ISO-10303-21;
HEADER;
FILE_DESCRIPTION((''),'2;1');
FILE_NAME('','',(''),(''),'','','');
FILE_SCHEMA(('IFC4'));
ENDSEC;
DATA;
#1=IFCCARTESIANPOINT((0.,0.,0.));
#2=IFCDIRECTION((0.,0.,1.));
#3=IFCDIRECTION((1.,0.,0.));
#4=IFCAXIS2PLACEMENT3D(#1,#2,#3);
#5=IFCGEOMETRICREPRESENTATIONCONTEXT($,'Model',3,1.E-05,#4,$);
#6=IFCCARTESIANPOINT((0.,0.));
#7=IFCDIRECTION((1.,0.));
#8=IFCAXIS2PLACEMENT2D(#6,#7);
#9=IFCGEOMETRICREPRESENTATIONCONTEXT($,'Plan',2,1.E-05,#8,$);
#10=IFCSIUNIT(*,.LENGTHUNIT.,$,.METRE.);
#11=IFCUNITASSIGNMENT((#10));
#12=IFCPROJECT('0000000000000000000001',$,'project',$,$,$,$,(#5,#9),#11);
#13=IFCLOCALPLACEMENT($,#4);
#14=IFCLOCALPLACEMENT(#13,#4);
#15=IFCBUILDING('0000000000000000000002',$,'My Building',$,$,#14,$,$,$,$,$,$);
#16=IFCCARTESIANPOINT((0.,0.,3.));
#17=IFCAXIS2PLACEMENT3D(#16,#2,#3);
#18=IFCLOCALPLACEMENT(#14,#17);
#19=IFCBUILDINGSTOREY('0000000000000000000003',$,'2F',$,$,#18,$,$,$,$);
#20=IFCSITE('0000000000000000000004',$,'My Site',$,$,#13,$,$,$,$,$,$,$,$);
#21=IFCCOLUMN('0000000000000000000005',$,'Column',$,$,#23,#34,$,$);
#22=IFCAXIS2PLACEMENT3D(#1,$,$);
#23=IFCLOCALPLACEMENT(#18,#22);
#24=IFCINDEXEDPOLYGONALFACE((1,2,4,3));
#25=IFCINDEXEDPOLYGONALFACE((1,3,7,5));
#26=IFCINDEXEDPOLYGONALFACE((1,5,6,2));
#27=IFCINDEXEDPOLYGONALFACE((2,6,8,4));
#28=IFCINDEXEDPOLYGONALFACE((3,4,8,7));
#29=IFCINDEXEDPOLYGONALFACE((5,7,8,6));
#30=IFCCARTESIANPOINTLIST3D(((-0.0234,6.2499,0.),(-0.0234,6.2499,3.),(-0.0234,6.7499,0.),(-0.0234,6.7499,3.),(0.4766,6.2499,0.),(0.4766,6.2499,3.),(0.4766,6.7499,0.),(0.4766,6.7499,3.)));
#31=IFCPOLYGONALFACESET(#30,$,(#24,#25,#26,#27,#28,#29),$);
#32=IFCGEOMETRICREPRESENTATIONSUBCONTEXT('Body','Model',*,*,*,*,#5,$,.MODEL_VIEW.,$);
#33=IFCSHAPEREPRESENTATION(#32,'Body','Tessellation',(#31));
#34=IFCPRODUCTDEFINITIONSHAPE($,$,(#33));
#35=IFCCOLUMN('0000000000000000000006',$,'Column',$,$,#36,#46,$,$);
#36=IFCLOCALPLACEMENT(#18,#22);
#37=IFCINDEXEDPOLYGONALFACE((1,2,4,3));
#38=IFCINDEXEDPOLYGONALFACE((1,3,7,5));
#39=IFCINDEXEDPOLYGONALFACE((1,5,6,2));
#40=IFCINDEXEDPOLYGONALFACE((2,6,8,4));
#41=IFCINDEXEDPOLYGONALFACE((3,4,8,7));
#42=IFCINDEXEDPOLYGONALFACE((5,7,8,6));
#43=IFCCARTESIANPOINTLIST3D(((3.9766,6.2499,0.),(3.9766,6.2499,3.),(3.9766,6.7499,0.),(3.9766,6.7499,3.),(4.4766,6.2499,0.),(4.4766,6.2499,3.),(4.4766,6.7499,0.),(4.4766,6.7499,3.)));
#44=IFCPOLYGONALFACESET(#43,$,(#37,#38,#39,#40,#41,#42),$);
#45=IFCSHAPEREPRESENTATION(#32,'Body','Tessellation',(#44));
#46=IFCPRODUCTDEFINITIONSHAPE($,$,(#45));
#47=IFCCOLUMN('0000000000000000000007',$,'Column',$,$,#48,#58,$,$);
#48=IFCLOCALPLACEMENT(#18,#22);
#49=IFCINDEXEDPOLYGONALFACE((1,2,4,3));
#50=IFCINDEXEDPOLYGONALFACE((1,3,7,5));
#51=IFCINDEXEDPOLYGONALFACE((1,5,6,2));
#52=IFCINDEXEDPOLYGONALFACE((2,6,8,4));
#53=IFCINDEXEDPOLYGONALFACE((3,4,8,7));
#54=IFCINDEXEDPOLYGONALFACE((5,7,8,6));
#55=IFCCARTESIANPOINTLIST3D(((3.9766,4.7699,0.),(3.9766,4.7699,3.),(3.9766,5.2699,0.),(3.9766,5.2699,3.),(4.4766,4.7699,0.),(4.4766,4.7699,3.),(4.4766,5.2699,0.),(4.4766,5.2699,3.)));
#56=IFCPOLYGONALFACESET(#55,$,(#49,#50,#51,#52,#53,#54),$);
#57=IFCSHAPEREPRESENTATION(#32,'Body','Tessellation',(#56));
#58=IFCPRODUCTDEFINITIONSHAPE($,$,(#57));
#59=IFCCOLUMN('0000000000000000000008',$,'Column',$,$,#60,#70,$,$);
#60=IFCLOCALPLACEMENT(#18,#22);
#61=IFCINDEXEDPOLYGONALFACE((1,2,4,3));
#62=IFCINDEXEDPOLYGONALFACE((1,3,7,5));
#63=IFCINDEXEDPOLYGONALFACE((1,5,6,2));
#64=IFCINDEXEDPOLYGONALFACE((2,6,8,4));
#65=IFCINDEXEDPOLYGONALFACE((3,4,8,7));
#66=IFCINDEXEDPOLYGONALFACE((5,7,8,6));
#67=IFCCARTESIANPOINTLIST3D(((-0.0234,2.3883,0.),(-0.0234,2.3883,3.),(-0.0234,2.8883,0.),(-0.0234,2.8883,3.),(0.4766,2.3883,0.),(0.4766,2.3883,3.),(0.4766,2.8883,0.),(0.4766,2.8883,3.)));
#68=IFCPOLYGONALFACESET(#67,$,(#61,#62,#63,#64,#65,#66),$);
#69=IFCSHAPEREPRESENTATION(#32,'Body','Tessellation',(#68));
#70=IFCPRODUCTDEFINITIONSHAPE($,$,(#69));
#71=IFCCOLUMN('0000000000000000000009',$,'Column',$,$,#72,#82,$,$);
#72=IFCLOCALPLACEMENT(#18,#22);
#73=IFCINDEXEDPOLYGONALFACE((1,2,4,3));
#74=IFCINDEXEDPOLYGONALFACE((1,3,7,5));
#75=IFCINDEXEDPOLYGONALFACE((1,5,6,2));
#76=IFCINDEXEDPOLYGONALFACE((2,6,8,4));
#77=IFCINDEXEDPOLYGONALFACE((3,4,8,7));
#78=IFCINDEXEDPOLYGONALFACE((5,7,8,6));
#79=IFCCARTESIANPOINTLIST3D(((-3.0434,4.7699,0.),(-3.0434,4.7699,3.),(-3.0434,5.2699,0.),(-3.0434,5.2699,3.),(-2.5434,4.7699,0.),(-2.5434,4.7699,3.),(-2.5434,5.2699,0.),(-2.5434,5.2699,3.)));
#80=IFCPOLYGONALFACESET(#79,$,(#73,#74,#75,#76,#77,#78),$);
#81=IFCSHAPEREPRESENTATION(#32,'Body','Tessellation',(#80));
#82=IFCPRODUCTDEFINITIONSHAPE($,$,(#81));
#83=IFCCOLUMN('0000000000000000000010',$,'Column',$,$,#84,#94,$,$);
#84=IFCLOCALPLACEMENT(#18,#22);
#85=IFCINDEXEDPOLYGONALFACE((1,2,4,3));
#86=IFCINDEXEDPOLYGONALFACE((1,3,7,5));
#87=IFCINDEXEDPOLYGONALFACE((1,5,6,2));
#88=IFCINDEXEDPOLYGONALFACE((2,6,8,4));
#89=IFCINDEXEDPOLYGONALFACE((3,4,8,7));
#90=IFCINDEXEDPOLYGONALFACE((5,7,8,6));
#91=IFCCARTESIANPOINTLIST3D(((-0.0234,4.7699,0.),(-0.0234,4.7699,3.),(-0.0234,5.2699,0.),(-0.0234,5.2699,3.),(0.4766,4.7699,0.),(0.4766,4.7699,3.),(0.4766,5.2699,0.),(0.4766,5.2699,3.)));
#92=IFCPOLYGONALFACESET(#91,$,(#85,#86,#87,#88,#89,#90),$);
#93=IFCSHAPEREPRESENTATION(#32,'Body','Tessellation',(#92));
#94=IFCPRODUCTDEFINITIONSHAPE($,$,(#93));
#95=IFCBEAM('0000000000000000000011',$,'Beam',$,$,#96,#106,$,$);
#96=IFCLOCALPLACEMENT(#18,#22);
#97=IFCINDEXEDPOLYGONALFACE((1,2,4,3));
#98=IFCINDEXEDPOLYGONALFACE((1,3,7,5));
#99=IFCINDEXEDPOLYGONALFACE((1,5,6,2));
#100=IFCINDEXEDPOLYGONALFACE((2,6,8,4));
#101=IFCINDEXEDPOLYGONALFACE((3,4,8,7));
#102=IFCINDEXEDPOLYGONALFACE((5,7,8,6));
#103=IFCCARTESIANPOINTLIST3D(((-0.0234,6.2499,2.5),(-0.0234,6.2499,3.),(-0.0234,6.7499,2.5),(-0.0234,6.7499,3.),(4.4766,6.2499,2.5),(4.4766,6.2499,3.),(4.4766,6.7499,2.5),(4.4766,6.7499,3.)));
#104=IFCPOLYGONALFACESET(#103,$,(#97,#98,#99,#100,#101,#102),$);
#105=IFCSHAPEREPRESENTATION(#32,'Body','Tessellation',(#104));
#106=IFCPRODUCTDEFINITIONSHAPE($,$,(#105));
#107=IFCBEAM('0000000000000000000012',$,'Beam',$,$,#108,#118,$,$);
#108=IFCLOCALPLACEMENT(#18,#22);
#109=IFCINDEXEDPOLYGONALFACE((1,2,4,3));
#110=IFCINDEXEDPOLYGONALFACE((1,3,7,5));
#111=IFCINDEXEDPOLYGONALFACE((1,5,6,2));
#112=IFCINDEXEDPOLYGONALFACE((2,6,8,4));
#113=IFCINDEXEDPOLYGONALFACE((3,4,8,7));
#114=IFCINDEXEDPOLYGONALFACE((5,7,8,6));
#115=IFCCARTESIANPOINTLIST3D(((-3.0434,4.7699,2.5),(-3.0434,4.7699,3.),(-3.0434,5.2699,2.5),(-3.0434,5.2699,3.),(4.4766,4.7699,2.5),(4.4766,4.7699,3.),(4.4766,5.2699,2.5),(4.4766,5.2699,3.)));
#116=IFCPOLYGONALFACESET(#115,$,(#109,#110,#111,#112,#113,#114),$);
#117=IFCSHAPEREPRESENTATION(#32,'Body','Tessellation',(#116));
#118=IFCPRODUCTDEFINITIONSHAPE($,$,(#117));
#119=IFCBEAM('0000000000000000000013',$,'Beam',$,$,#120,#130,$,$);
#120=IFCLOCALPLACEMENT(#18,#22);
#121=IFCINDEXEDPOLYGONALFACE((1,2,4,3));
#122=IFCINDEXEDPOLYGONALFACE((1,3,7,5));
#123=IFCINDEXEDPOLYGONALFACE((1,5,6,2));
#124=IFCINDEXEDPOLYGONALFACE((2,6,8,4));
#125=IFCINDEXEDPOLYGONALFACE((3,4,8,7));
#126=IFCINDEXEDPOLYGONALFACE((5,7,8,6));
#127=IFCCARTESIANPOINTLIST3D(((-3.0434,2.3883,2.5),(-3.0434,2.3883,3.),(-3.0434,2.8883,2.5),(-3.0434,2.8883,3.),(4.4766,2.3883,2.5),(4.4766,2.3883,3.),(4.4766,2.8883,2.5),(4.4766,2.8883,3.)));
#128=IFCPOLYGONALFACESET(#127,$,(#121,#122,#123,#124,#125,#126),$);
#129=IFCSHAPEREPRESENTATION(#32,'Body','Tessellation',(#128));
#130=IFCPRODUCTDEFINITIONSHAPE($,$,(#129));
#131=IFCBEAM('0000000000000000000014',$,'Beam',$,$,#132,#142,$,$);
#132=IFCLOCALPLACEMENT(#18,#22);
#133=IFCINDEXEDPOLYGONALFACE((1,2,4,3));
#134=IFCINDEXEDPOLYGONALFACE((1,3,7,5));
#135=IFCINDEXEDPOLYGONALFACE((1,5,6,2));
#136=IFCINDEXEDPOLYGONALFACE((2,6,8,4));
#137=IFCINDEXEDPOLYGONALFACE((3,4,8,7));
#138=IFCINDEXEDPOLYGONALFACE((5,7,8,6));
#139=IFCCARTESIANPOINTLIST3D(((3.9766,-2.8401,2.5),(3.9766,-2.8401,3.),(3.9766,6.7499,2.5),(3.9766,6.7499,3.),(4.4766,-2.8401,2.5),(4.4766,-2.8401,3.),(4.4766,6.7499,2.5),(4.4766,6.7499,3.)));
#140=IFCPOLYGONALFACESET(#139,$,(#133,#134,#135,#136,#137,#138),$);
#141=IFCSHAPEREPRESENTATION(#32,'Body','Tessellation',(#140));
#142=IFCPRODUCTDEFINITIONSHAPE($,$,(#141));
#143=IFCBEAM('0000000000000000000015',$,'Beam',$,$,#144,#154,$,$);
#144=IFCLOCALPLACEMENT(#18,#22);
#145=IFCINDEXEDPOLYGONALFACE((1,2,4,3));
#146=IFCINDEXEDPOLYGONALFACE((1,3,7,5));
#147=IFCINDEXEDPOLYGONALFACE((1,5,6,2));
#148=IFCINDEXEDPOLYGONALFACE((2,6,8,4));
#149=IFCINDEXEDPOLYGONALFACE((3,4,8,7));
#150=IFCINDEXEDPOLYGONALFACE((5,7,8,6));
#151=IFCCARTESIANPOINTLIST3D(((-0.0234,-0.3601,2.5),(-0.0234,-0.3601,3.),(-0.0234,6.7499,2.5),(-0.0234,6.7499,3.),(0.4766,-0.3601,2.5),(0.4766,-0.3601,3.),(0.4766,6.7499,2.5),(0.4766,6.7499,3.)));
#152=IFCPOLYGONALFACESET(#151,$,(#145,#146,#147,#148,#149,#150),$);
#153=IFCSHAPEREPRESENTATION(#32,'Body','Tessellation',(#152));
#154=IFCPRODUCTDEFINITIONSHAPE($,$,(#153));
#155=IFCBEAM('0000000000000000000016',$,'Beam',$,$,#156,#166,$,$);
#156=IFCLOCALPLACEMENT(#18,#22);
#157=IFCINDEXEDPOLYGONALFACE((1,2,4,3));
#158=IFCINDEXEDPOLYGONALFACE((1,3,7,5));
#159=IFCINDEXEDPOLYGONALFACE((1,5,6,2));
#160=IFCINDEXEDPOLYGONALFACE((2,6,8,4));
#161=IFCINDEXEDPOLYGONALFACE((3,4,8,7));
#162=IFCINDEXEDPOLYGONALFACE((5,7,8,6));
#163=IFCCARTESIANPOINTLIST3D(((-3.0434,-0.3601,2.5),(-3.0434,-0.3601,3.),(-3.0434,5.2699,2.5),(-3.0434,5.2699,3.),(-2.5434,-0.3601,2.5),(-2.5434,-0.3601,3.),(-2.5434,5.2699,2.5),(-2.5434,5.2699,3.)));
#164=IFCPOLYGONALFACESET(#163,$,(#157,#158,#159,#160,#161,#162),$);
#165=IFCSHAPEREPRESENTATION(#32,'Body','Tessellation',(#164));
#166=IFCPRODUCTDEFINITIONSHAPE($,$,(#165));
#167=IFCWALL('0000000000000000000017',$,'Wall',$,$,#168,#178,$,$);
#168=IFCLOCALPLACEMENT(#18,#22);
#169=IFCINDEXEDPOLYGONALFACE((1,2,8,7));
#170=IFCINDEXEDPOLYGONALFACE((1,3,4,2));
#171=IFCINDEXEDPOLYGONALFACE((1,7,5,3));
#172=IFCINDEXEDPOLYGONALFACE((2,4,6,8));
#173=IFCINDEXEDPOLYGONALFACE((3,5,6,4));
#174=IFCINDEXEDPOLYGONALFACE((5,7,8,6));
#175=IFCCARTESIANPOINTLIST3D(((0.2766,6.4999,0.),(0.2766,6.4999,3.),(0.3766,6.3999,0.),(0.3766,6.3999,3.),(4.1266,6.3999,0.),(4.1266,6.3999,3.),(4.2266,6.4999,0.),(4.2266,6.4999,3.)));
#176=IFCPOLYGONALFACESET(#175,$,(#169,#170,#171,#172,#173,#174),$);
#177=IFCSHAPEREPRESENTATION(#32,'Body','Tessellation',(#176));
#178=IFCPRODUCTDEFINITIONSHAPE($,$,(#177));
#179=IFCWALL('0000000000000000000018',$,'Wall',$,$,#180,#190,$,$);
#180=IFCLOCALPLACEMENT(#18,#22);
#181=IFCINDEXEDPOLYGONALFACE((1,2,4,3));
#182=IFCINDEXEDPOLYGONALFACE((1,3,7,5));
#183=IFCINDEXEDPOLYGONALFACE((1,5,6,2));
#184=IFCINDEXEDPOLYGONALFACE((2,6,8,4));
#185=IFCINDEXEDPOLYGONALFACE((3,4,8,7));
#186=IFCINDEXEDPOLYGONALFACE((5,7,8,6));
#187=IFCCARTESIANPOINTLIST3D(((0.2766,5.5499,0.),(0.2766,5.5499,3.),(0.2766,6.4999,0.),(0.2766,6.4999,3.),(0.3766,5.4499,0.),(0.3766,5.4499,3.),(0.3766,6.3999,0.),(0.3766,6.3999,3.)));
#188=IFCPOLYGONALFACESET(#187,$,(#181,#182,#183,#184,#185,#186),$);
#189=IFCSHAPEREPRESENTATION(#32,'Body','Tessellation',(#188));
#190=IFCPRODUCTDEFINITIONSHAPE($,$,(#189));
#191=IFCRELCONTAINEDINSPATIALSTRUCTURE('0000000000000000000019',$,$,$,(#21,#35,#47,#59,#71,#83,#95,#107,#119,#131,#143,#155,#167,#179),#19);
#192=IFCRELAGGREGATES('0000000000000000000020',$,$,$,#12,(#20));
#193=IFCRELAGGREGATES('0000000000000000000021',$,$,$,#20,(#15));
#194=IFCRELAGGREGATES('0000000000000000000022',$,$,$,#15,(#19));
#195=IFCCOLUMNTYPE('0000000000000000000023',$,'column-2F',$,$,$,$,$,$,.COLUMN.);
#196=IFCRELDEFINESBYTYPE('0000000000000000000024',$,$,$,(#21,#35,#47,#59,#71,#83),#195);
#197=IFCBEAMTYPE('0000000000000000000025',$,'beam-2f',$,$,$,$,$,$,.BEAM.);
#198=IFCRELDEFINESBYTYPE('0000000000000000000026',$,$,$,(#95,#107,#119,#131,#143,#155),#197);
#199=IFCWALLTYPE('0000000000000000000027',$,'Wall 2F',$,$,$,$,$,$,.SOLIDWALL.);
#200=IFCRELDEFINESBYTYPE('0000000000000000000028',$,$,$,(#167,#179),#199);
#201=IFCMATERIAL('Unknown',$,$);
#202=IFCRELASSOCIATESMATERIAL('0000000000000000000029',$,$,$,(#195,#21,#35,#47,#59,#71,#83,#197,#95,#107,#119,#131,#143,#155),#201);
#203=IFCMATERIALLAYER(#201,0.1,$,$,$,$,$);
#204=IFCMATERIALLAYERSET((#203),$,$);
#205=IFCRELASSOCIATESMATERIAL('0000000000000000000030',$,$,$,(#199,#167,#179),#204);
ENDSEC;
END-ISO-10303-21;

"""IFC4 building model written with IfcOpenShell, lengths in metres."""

from ifc_helpers import new_model, si_unit, frame, origin_with_axes, origin_2d_with_axis, place, context, subcontext, project, spatial, line, indexed_curve, rectangle, outline, extrude, material, layer, layer_set, layer_usage, material_profile, profile_set, profile_usage, type_object, element, save


model = new_model("IFC4")

# Units and contexts
model_context = context("Model", 3, precision=1e-05, world=origin_with_axes())
plan_context = context("Plan", 2, precision=1e-05, world=origin_2d_with_axis())
body_context_1 = subcontext(model_context, "Body", "Model", "MODEL_VIEW")
ifc_project = project(units=[si_unit("LENGTHUNIT", "METRE")], contexts=[model_context, plan_context])

# Site, building, storey
site_placement = place(None, origin_with_axes())
site = spatial("IfcSite", under=ifc_project, at=site_placement, Name="My Site")
building_placement = place(site_placement, origin_with_axes())
building = spatial("IfcBuilding", under=site, at=building_placement, Name="My Building")
storey_placement = place(building_placement, frame((0.0, 0.0, 3.0), z_axis=(0.0, 0.0, 1.0), x_axis=(1.0, 0.0, 0.0)))
storey = spatial("IfcBuildingStorey", under=building, at=storey_placement, Name="2F")

# Columns
ifc_material = material(Name="Unknown")
ifc_material_profile_1 = material_profile(ifc_material, rectangle(XDim=0.5, YDim=0.5))
ifc_profile_set_1 = profile_set([ifc_material_profile_1])
ifc_profile_usage_1 = profile_usage(ifc_profile_set_1, cardinal=7)
column_type = type_object("IfcColumnType", Name="column-2F", PredefinedType="COLUMN", material=ifc_profile_set_1)
column_1_placement = place(storey_placement, frame((0.4766, 6.7499, 0.0), z_axis=(0.0, 0.0, 1.0), x_axis=(1.0, 0.0, 0.0)))
element("IfcColumn", 1, at=column_1_placement, inside=storey, type_object=column_type, material=ifc_profile_usage_1, Name="Column", context=body_context_1, shape_type="SweptSolid", body=[
    extrude(rectangle(XDim=0.5, YDim=0.5), frame((-0.25, -0.25, 0.0), z_axis=(0.0, 0.0, 1.0), x_axis=(1.0, 0.0, 0.0)), (0.0, 0.0, 1.0), 3.0),
])
ifc_profile_usage_2 = profile_usage(ifc_profile_set_1, cardinal=7)
column_2_placement = place(storey_placement, frame((4.4766, 6.7499, 0.0), z_axis=(0.0, 0.0, 1.0), x_axis=(1.0, 0.0, 0.0)))
element("IfcColumn", 2, at=column_2_placement, inside=storey, type_object=column_type, material=ifc_profile_usage_2, Name="Column", context=body_context_1, shape_type="SweptSolid", body=[
    extrude(rectangle(XDim=0.5, YDim=0.5), frame((-0.25, -0.25, 0.0), z_axis=(0.0, 0.0, 1.0), x_axis=(1.0, 0.0, 0.0)), (0.0, 0.0, 1.0), 3.0),
])
ifc_profile_usage_3 = profile_usage(ifc_profile_set_1, cardinal=7)
column_3_placement = place(storey_placement, frame((4.4766, 5.2699, 0.0), z_axis=(0.0, 0.0, 1.0), x_axis=(1.0, 0.0, 0.0)))
element("IfcColumn", 3, at=column_3_placement, inside=storey, type_object=column_type, material=ifc_profile_usage_3, Name="Column", context=body_context_1, shape_type="SweptSolid", body=[
    extrude(rectangle(XDim=0.5, YDim=0.5), frame((-0.25, -0.25, 0.0), z_axis=(0.0, 0.0, 1.0), x_axis=(1.0, 0.0, 0.0)), (0.0, 0.0, 1.0), 3.0),
])
ifc_profile_usage_4 = profile_usage(ifc_profile_set_1, cardinal=7)
column_4_placement = place(storey_placement, frame((0.4766, 2.8883, 0.0), z_axis=(0.0, 0.0, 1.0), x_axis=(1.0, 0.0, 0.0)))
element("IfcColumn", 4, at=column_4_placement, inside=storey, type_object=column_type, material=ifc_profile_usage_4, Name="Column", context=body_context_1, shape_type="SweptSolid", body=[
    extrude(rectangle(XDim=0.5, YDim=0.5), frame((-0.25, -0.25, 0.0), z_axis=(0.0, 0.0, 1.0), x_axis=(1.0, 0.0, 0.0)), (0.0, 0.0, 1.0), 3.0),
])
ifc_profile_usage_5 = profile_usage(ifc_profile_set_1, cardinal=7)
column_5_placement = place(storey_placement, frame((-2.5434, 5.2699, 0.0), z_axis=(0.0, 0.0, 1.0), x_axis=(1.0, 0.0, 0.0)))
element("IfcColumn", 5, at=column_5_placement, inside=storey, type_object=column_type, material=ifc_profile_usage_5, Name="Column", context=body_context_1, shape_type="SweptSolid", body=[
    extrude(rectangle(XDim=0.5, YDim=0.5), frame((-0.25, -0.25, 0.0), z_axis=(0.0, 0.0, 1.0), x_axis=(1.0, 0.0, 0.0)), (0.0, 0.0, 1.0), 3.0),
])
ifc_profile_usage_6 = profile_usage(ifc_profile_set_1, cardinal=7)
column_6_placement = place(storey_placement, frame((0.4766, 5.2699, 0.0), z_axis=(0.0, 0.0, 1.0), x_axis=(1.0, 0.0, 0.0)))
element("IfcColumn", 6, at=column_6_placement, inside=storey, type_object=column_type, material=ifc_profile_usage_6, Name="Column", context=body_context_1, shape_type="SweptSolid", body=[
    extrude(rectangle(XDim=0.5, YDim=0.5), frame((-0.25, -0.25, 0.0), z_axis=(0.0, 0.0, 1.0), x_axis=(1.0, 0.0, 0.0)), (0.0, 0.0, 1.0), 3.0),
])

# Beams
ifc_material_profile_2 = material_profile(ifc_material, rectangle(XDim=0.5, YDim=0.5))
ifc_profile_set_2 = profile_set([ifc_material_profile_2])
ifc_profile_usage_7 = profile_usage(ifc_profile_set_2, cardinal=7)
beam_type = type_object("IfcBeamType", Name="beam-2f", PredefinedType="BEAM", material=ifc_profile_set_2)
beam_1_placement = place(storey_placement, frame((-0.0234, 6.7499, 3.0), z_axis=(1.0, -0.000001, 0.000001), x_axis=(0.000001, 1.0, 0.0)))
element("IfcBeam", 7, at=beam_1_placement, inside=storey, type_object=beam_type, material=ifc_profile_usage_7, Name="Beam", context=body_context_1, shape_type="SweptSolid", body=[
    extrude(rectangle(XDim=0.5, YDim=0.5), frame((-0.25, -0.25, 0.0), z_axis=(0.0, 0.0, 1.0), x_axis=(1.0, 0.0, 0.0)), (0.0, 0.0, 1.0), 4.5),
])
ifc_profile_usage_8 = profile_usage(ifc_profile_set_2, cardinal=7)
beam_2_placement = place(storey_placement, frame((-3.0434, 5.2699, 3.0), z_axis=(1.0, -0.000001, 0.000001), x_axis=(0.000001, 1.0, 0.0)))
element("IfcBeam", 8, at=beam_2_placement, inside=storey, type_object=beam_type, material=ifc_profile_usage_8, Name="Beam", context=body_context_1, shape_type="SweptSolid", body=[
    extrude(rectangle(XDim=0.5, YDim=0.5), frame((-0.25, -0.25, 0.0), z_axis=(0.0, 0.0, 1.0), x_axis=(1.0, 0.0, 0.0)), (0.0, 0.0, 1.0), 7.52),
])
ifc_profile_usage_9 = profile_usage(ifc_profile_set_2, cardinal=7)
beam_3_placement = place(storey_placement, frame((-3.0434, 2.8883, 3.0), z_axis=(1.0, -0.000001, 0.000001), x_axis=(0.000001, 1.0, 0.0)))
element("IfcBeam", 9, at=beam_3_placement, inside=storey, type_object=beam_type, material=ifc_profile_usage_9, Name="Beam", context=body_context_1, shape_type="SweptSolid", body=[
    extrude(rectangle(XDim=0.5, YDim=0.5), frame((-0.25, -0.25, 0.0), z_axis=(0.0, 0.0, 1.0), x_axis=(1.0, 0.0, 0.0)), (0.0, 0.0, 1.0), 7.52),
])
ifc_profile_usage_10 = profile_usage(ifc_profile_set_2, cardinal=7)
beam_4_placement = place(storey_placement, frame((4.4766, 6.7499, 3.0), z_axis=(0.0, -1.0, 0.0), x_axis=(1.0, 0.0, 0.0)))
element("IfcBeam", 10, at=beam_4_placement, inside=storey, type_object=beam_type, material=ifc_profile_usage_10, Name="Beam", context=body_context_1, shape_type="SweptSolid", body=[
    extrude(rectangle(XDim=0.5, YDim=0.5), frame((-0.25, -0.25, 0.0), z_axis=(0.0, 0.0, 1.0), x_axis=(1.0, 0.0, 0.0)), (0.0, 0.0, 1.0), 9.59),
])
ifc_profile_usage_11 = profile_usage(ifc_profile_set_2, cardinal=7)
beam_5_placement = place(storey_placement, frame((0.4766, 6.7499, 3.0), z_axis=(0.0, -1.0, 0.0), x_axis=(1.0, 0.0, 0.0)))
element("IfcBeam", 11, at=beam_5_placement, inside=storey, type_object=beam_type, material=ifc_profile_usage_11, Name="Beam", context=body_context_1, shape_type="SweptSolid", body=[
    extrude(rectangle(XDim=0.5, YDim=0.5), frame((-0.25, -0.25, 0.0), z_axis=(0.0, 0.0, 1.0), x_axis=(1.0, 0.0, 0.0)), (0.0, 0.0, 1.0), 7.11),
])
ifc_profile_usage_12 = profile_usage(ifc_profile_set_2, cardinal=7)
beam_6_placement = place(storey_placement, frame((-2.5434, 5.2699, 3.0), z_axis=(0.0, -1.0, 0.0), x_axis=(1.0, 0.0, 0.0)))
element("IfcBeam", 12, at=beam_6_placement, inside=storey, type_object=beam_type, material=ifc_profile_usage_12, Name="Beam", context=body_context_1, shape_type="SweptSolid", body=[
    extrude(rectangle(XDim=0.5, YDim=0.5), frame((-0.25, -0.25, 0.0), z_axis=(0.0, 0.0, 1.0), x_axis=(1.0, 0.0, 0.0)), (0.0, 0.0, 1.0), 5.63),
])

# Walls
ifc_layer = layer(ifc_material, 0.1)
ifc_layer_set = layer_set([ifc_layer])
ifc_layer_usage_1 = layer_usage(ifc_layer_set, "AXIS2", "POSITIVE", 0.0)
wall_type = type_object("IfcWallType", Name="Wall 2F", PredefinedType="SOLIDWALL", material=ifc_layer_set)
wall_1_placement = place(storey_placement, frame((4.2266, 6.4999, 0.0), z_axis=(0.0, 0.0, 1.0), x_axis=(-1.0, 0.0, 0.0)))
element("IfcWall", 13, at=wall_1_placement, inside=storey, type_object=wall_type, material=ifc_layer_usage_1, Name="Wall", context=body_context_1, shape_type="SweptSolid", body=[
    extrude(outline(indexed_curve([(0.0, 0.0), (0.1, 0.1), (3.85, 0.1), (3.95, 0.0)], segments=[line(1, 2, 3, 4, 1)])), origin_with_axes(), (0.0, 0.0, 1.0), 3.0),
])
ifc_layer_usage_2 = layer_usage(ifc_layer_set, "AXIS2", "POSITIVE", 0.0)
wall_2_placement = place(storey_placement, frame((0.2766, 6.4999, 0.0), z_axis=(0.0, 0.0, 1.0), x_axis=(0.0, -1.0, 0.0)))
element("IfcWall", 14, at=wall_2_placement, inside=storey, type_object=wall_type, material=ifc_layer_usage_2, Name="Wall", context=body_context_1, shape_type="SweptSolid", body=[
    extrude(outline(indexed_curve([(0.0, 0.0), (0.1, 0.1), (1.05, 0.1), (0.95, 0.0)], segments=[line(1, 2, 3, 4, 1)])), origin_with_axes(), (0.0, 0.0, 1.0), 3.0),
])

save(model, "model.ifc")
